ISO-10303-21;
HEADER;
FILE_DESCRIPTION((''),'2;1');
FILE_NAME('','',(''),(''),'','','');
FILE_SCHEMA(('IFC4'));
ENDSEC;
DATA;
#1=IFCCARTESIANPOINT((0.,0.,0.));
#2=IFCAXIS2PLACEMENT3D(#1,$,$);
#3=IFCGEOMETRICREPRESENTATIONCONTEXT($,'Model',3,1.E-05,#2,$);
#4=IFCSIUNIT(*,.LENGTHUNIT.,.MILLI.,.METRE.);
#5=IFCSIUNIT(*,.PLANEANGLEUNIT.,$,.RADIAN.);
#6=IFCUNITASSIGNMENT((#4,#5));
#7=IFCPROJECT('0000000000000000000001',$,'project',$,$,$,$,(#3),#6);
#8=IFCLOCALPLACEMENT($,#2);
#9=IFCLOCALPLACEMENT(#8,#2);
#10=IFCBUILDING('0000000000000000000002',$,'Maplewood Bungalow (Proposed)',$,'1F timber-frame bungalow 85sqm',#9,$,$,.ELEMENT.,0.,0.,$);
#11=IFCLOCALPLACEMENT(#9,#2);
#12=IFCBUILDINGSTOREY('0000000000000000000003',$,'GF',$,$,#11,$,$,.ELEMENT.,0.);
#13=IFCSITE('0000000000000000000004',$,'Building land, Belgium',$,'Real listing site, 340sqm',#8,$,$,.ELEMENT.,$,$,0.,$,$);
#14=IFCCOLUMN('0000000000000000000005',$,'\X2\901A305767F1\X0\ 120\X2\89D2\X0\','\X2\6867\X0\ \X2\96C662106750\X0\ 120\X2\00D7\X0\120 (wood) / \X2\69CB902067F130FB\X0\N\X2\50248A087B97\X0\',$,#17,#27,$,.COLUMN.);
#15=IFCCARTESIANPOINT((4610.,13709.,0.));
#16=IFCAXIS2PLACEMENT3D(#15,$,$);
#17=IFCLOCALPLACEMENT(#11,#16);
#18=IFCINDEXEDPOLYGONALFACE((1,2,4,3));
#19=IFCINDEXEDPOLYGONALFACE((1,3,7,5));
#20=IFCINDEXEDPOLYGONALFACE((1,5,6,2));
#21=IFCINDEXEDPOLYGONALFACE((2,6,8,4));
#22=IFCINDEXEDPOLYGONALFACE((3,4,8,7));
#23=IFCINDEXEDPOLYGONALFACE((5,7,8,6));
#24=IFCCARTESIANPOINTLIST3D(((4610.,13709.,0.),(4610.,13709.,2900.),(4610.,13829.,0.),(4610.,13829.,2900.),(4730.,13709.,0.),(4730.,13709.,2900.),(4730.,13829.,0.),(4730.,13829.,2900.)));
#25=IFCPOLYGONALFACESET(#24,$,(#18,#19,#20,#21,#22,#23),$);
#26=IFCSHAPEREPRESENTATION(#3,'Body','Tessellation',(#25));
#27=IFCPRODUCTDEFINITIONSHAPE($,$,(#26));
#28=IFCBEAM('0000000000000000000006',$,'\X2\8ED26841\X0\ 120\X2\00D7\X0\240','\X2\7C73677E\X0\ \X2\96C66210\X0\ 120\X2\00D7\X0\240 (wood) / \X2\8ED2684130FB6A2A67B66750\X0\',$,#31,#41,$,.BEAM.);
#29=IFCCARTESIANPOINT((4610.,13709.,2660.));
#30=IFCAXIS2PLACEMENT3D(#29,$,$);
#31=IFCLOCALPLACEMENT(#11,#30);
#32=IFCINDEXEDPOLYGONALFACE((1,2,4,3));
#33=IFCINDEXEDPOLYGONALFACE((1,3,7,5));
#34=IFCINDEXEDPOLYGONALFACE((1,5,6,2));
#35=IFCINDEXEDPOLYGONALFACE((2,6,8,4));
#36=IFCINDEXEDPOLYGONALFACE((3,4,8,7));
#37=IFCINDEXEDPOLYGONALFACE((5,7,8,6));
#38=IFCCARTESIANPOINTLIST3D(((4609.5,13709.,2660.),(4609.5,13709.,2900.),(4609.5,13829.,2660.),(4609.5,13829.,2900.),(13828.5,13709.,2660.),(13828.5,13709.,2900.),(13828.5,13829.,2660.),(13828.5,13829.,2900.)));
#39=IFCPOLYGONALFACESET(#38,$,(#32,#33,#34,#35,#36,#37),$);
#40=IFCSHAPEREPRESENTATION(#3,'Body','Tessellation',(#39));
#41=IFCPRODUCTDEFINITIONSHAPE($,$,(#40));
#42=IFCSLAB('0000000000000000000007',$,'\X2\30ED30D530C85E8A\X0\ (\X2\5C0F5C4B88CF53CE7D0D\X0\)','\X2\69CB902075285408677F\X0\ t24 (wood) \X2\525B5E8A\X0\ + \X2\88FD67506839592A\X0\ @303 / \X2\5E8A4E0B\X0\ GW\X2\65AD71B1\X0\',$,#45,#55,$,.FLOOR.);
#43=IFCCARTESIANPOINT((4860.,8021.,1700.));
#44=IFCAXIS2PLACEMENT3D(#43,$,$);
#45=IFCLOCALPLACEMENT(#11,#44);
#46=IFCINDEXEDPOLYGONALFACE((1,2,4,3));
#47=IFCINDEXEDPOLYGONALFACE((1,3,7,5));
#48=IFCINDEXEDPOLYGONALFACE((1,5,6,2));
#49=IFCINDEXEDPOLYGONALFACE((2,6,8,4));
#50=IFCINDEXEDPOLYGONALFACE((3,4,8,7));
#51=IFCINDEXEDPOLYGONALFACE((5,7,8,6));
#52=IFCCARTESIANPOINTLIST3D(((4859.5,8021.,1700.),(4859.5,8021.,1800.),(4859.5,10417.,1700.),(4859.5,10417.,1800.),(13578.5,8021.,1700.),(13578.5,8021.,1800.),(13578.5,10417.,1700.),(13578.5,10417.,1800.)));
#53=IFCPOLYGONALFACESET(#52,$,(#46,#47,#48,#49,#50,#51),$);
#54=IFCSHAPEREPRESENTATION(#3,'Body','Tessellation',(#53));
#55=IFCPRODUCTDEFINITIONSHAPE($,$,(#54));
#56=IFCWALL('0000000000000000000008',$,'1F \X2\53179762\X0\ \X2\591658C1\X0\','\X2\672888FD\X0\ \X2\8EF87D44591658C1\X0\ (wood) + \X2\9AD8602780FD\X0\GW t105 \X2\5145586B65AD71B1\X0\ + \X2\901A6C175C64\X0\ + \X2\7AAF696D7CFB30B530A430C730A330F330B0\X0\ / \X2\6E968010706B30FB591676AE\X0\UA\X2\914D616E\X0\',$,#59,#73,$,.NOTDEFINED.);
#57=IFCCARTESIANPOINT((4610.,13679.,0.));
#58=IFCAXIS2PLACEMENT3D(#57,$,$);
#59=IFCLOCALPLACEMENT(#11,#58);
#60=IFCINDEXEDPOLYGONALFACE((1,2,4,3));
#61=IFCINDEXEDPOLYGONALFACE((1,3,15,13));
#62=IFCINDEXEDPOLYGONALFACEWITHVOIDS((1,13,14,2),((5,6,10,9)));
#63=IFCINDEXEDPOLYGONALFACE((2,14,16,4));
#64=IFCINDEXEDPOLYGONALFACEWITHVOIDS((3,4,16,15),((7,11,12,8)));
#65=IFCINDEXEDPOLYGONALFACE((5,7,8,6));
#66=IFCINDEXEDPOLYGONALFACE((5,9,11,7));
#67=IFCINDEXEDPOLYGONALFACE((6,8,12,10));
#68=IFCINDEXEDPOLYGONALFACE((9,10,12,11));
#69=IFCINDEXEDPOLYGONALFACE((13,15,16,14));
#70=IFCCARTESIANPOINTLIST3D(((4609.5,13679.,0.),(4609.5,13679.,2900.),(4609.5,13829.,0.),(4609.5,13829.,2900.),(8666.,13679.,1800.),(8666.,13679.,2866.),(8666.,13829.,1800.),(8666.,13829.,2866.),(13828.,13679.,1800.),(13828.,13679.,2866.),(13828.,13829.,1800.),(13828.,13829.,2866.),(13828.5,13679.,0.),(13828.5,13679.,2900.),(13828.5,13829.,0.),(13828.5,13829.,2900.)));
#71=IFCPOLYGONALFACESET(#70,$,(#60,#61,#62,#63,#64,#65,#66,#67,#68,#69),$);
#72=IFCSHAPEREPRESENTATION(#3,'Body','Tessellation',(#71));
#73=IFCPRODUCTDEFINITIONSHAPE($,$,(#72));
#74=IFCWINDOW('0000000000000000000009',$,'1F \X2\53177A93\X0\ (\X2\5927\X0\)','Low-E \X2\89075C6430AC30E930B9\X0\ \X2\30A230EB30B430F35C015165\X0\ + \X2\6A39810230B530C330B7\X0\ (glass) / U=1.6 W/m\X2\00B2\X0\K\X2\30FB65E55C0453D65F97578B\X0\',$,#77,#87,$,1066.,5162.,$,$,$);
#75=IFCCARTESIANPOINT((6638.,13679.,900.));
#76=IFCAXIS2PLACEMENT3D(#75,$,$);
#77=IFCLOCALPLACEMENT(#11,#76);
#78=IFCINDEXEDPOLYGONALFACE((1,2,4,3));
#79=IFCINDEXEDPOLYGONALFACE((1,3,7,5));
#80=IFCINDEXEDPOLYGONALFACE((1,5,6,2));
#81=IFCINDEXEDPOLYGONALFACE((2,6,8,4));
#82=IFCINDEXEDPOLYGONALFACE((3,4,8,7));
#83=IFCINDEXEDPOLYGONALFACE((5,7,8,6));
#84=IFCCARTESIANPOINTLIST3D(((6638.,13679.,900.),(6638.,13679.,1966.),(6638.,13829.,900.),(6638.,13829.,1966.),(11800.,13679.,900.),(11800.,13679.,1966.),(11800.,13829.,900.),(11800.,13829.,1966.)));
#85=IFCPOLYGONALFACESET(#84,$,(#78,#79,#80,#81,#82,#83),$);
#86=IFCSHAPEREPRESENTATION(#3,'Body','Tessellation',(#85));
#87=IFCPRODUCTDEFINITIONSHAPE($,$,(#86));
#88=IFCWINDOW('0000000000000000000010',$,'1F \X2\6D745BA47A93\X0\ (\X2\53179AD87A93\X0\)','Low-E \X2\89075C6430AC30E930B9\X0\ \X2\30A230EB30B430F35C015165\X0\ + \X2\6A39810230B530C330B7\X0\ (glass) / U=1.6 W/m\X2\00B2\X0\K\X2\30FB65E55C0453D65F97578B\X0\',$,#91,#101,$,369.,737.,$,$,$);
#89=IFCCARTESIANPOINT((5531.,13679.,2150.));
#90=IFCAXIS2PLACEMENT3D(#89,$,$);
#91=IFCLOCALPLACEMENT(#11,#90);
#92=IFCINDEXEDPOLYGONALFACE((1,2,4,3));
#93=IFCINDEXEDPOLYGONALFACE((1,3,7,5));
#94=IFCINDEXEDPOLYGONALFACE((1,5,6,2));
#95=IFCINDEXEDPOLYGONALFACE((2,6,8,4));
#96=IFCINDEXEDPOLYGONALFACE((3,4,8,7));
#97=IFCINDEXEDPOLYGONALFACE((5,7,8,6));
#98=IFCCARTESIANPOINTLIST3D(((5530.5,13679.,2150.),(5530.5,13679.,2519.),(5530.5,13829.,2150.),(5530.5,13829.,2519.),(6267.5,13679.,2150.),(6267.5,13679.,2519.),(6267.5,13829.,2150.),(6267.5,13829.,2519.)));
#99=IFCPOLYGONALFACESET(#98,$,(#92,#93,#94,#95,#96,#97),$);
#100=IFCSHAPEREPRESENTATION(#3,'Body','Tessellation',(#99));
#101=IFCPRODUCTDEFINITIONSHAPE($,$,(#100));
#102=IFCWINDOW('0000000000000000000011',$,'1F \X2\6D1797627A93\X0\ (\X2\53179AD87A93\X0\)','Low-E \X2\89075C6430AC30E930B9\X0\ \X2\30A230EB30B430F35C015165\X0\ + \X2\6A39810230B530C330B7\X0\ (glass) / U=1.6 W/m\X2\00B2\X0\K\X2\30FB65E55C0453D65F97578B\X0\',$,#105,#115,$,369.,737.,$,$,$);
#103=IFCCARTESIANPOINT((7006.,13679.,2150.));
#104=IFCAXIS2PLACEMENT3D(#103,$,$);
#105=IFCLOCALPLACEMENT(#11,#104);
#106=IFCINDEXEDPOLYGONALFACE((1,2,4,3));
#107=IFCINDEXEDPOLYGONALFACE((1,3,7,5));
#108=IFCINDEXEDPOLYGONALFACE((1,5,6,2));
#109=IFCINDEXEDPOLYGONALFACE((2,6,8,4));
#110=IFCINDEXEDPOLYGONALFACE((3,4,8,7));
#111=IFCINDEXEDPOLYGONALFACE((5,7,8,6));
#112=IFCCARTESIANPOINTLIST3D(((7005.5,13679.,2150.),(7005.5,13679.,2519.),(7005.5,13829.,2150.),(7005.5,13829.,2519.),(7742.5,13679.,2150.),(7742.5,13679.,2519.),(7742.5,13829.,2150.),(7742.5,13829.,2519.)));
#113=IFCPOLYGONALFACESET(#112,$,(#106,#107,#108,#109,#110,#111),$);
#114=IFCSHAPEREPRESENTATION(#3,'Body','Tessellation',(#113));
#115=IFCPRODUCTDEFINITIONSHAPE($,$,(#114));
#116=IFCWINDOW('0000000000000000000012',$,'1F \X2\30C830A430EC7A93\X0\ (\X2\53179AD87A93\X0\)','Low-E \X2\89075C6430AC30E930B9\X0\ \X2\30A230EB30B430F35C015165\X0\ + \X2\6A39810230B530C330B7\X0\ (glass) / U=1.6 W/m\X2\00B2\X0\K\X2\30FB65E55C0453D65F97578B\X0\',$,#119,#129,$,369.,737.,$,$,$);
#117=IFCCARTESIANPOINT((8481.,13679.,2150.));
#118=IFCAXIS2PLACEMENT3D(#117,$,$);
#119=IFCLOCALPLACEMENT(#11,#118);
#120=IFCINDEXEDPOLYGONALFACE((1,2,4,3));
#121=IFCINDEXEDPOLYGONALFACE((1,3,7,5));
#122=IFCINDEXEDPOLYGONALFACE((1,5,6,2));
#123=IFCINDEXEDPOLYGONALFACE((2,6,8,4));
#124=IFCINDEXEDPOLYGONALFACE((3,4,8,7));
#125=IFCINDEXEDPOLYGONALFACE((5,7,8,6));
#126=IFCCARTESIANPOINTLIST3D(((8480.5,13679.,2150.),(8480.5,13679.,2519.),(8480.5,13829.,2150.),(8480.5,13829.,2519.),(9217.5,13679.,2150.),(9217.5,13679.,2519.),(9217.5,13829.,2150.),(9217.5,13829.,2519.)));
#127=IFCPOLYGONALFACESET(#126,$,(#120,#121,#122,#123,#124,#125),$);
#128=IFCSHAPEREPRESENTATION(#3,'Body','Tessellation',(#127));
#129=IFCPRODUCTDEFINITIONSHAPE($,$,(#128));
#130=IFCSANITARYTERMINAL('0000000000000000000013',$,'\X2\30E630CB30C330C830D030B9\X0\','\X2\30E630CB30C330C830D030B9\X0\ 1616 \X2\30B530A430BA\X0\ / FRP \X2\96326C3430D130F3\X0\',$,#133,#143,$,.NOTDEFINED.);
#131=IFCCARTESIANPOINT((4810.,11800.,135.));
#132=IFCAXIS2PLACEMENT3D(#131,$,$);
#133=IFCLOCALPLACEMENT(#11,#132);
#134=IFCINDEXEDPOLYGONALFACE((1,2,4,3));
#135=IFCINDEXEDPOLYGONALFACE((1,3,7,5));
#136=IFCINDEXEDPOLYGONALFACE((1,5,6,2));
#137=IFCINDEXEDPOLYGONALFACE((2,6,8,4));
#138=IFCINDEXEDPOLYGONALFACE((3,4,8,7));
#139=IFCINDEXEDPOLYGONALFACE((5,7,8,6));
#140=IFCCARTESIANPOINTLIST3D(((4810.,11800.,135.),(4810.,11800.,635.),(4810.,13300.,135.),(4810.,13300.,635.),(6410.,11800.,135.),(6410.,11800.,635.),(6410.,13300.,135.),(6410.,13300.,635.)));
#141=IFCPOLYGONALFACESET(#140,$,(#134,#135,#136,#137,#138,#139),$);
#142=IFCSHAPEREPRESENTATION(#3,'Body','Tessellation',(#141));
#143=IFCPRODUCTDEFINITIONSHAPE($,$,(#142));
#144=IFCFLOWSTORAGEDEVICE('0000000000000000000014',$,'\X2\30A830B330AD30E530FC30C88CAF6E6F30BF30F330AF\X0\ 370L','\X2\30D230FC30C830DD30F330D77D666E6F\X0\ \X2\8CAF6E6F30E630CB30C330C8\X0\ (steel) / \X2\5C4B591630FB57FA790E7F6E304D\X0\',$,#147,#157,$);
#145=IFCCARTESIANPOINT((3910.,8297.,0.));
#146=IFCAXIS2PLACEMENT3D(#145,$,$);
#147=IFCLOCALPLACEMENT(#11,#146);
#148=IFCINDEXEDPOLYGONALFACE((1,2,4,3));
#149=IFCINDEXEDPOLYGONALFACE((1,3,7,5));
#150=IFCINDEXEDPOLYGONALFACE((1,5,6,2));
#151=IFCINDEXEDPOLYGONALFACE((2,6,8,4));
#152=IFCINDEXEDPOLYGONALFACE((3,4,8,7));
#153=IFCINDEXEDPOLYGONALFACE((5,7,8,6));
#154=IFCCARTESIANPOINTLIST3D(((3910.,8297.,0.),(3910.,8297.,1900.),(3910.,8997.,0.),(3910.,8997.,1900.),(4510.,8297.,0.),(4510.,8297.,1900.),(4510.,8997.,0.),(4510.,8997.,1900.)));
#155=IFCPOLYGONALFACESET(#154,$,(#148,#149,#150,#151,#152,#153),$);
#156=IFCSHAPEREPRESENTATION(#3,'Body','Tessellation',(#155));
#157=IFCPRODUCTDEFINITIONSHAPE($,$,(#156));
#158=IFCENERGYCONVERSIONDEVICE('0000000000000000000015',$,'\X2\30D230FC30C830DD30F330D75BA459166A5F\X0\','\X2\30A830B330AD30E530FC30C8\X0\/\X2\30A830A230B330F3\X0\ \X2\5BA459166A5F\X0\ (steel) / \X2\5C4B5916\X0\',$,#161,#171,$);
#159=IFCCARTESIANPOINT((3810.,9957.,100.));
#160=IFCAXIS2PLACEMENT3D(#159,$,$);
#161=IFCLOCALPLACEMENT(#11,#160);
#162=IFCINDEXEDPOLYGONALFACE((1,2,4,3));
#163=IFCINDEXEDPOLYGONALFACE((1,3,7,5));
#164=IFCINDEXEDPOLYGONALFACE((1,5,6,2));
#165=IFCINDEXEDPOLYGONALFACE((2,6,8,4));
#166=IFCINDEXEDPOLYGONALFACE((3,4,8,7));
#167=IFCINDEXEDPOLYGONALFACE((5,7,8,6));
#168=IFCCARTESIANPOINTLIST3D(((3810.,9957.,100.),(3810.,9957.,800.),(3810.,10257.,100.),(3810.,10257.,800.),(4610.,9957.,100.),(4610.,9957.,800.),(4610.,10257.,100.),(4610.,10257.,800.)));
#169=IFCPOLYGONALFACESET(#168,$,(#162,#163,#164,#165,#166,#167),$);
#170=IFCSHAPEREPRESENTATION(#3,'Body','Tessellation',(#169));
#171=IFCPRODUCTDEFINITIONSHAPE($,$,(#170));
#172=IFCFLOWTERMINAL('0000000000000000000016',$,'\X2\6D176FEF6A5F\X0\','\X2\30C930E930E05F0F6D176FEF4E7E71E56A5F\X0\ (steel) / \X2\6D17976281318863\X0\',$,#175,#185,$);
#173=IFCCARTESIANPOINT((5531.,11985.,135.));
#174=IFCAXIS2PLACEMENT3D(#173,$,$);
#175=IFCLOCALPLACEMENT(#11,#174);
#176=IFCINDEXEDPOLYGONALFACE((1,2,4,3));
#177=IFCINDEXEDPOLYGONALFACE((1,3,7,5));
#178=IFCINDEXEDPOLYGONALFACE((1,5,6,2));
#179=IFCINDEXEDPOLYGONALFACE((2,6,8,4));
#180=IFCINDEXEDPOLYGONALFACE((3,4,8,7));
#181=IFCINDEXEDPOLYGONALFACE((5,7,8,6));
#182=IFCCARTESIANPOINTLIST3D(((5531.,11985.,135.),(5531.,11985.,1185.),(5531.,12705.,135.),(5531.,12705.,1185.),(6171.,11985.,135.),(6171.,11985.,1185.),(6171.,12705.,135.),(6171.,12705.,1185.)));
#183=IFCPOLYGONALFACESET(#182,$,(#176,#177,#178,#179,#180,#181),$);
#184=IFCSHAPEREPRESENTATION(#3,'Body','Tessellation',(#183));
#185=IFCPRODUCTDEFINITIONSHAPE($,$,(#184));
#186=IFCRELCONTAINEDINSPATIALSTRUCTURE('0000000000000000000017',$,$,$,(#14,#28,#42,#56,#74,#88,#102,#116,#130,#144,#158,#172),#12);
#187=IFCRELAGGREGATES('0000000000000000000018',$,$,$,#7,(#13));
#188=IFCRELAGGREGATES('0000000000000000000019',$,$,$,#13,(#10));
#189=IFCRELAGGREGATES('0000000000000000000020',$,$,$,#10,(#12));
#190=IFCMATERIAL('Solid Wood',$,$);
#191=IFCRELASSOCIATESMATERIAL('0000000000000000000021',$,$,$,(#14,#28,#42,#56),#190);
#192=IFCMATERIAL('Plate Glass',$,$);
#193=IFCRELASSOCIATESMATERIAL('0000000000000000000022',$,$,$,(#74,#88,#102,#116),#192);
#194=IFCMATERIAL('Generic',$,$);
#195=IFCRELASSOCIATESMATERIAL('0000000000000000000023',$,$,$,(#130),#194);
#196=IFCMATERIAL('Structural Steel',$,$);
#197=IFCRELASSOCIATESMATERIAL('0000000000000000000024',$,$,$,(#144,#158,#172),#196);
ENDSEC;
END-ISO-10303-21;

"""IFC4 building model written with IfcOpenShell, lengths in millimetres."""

from ifc_helpers import new_model, si_unit, frame, frame_2d, origin, place, context, project, spatial, rectangle, extrude, material, element, fill, save


model = new_model("IFC4")

# Units and contexts
model_context = context("Model", 3, precision=1e-05, world=origin())
ifc_project = project(units=[si_unit("LENGTHUNIT", "METRE", prefix="MILLI"), si_unit("PLANEANGLEUNIT", "RADIAN")], contexts=[model_context])

# Site, building, storey
site_placement = place(None, origin())
site = spatial("IfcSite", under=ifc_project, at=site_placement, Name="Building land, Belgium", ObjectType="Real listing site, 340sqm", CompositionType="ELEMENT", RefElevation=0.0)
building_placement = place(site_placement, origin())
building = spatial("IfcBuilding", under=site, at=building_placement, Name="Maplewood Bungalow (Proposed)", ObjectType="1F timber-frame bungalow 85sqm", CompositionType="ELEMENT", ElevationOfRefHeight=0.0, ElevationOfTerrain=0.0)
storey_placement = place(building_placement, origin())
storey = spatial("IfcBuildingStorey", under=building, at=storey_placement, Name="GF", CompositionType="ELEMENT", Elevation=0.0)

# Column
ifc_material_1 = material(Name="Solid Wood")
column_1_placement = place(storey_placement, frame((4610.0, 13709.0, 0.0)))
element("IfcColumn", 1, at=column_1_placement, inside=storey, material=ifc_material_1, Name="通し柱 120角", Description="桧 集成材 120×120 (wood) / 構造柱・N値計算", PredefinedType="COLUMN", context=model_context, shape_type="SweptSolid", body=[
    extrude(rectangle(XDim=120.0, YDim=120.0, at=frame_2d((60.0, 60.0))), frame((4610.0, 13709.0, 0.0)), (0.0, 0.0, 1.0), 2900.0),
])

# Beam
beam_1_placement = place(storey_placement, frame((4610.0, 13709.0, 2660.0)))
element("IfcBeam", 2, at=beam_1_placement, inside=storey, material=ifc_material_1, Name="軒桁 120×240", Description="米松 集成 120×240 (wood) / 軒桁・横架材", PredefinedType="BEAM", context=model_context, shape_type="SweptSolid", body=[
    extrude(rectangle(XDim=9219.0, YDim=120.0, at=frame_2d((4609.0, 60.0))), frame((4610.0, 13709.0, 2660.0)), (0.0, 0.0, 1.0), 240.0),
])

# Slab
slab_placement = place(storey_placement, frame((4860.0, 8021.0, 1700.0)))
element("IfcSlab", 3, at=slab_placement, inside=storey, material=ifc_material_1, Name="ロフト床 (小屋裏収納)", Description="構造用合板 t24 (wood) 剛床 + 製材根太 @303 / 床下 GW断熱", PredefinedType="FLOOR", context=model_context, shape_type="SweptSolid", body=[
    extrude(rectangle(XDim=8719.0, YDim=2396.0, at=frame_2d((4359.0, 1198.0))), frame((4860.0, 8021.0, 1700.0)), (0.0, 0.0, 1.0), 100.0),
])

# Wall, openings, windows
wall_1_placement = place(storey_placement, frame((4610.0, 13679.0, 0.0)))
wall_1 = element("IfcWall", 4, at=wall_1_placement, inside=storey, material=ifc_material_1, Name="1F 北面 外壁", Description="木製 軸組外壁 (wood) + 高性能GW t105 充填断熱 + 通気層 + 窯業系サイディング / 準耐火・外皮UA配慮", PredefinedType="NOTDEFINED", context=model_context, shape_type="SweptSolid", body=[
    extrude(rectangle(XDim=9219.0, YDim=150.0, at=frame_2d((4609.0, 75.0))), frame((4610.0, 13679.0, 0.0)), (0.0, 0.0, 1.0), 2900.0),
])
opening_1_placement = place(storey_placement, frame((6638.0, 13679.0, 900.0)))
opening_1 = element("IfcOpeningElement", 5, at=opening_1_placement, cuts=wall_1, PredefinedType="NOTDEFINED", context=model_context, shape_type="SweptSolid", body=[
    extrude(rectangle(XDim=5162.0, YDim=150.0, at=frame_2d((2581.0, 75.0))), frame((6638.0, 13679.0, 900.0)), (0.0, 0.0, 1.0), 1066.0),
])
opening_2_placement = place(storey_placement, frame((5531.0, 13679.0, 2150.0)))
opening_2 = element("IfcOpeningElement", 6, at=opening_2_placement, cuts=wall_1, PredefinedType="NOTDEFINED", context=model_context, shape_type="SweptSolid", body=[
    extrude(rectangle(XDim=737.0, YDim=150.0, at=frame_2d((368.0, 75.0))), frame((5531.0, 13679.0, 2150.0)), (0.0, 0.0, 1.0), 369.0),
])
opening_3_placement = place(storey_placement, frame((7006.0, 13679.0, 2150.0)))
opening_3 = element("IfcOpeningElement", 7, at=opening_3_placement, cuts=wall_1, PredefinedType="NOTDEFINED", context=model_context, shape_type="SweptSolid", body=[
    extrude(rectangle(XDim=737.0, YDim=150.0, at=frame_2d((368.0, 75.0))), frame((7006.0, 13679.0, 2150.0)), (0.0, 0.0, 1.0), 369.0),
])
opening_4_placement = place(storey_placement, frame((8481.0, 13679.0, 2150.0)))
opening_4 = element("IfcOpeningElement", 8, at=opening_4_placement, cuts=wall_1, PredefinedType="NOTDEFINED", context=model_context, shape_type="SweptSolid", body=[
    extrude(rectangle(XDim=737.0, YDim=150.0, at=frame_2d((368.0, 75.0))), frame((8481.0, 13679.0, 2150.0)), (0.0, 0.0, 1.0), 369.0),
])
ifc_material_2 = material(Name="Plate Glass")
window_1_placement = place(storey_placement, frame((6638.0, 13679.0, 900.0)))
window_1 = element("IfcWindow", 9, at=window_1_placement, inside=storey, material=ifc_material_2, Name="1F 北窓 (大)", Description="Low-E 複層ガラス アルゴン封入 + 樹脂サッシ (glass) / U=1.6 W/m²K・日射取得型", OverallHeight=1066.0, OverallWidth=5162.0, context=model_context, shape_type="SweptSolid", body=[
    extrude(rectangle(XDim=5162.0, YDim=150.0, at=frame_2d((2581.0, 75.0))), frame((6638.0, 13679.0, 900.0)), (0.0, 0.0, 1.0), 1066.0),
])
fill(opening_1, window_1)
window_2_placement = place(storey_placement, frame((5531.0, 13679.0, 2150.0)))
window_2 = element("IfcWindow", 10, at=window_2_placement, inside=storey, material=ifc_material_2, Name="1F 浴室窓 (北高窓)", Description="Low-E 複層ガラス アルゴン封入 + 樹脂サッシ (glass) / U=1.6 W/m²K・日射取得型", OverallHeight=369.0, OverallWidth=737.0, context=model_context, shape_type="SweptSolid", body=[
    extrude(rectangle(XDim=737.0, YDim=150.0, at=frame_2d((368.0, 75.0))), frame((5531.0, 13679.0, 2150.0)), (0.0, 0.0, 1.0), 369.0),
])
fill(opening_2, window_2)
window_3_placement = place(storey_placement, frame((7006.0, 13679.0, 2150.0)))
window_3 = element("IfcWindow", 11, at=window_3_placement, inside=storey, material=ifc_material_2, Name="1F 洗面窓 (北高窓)", Description="Low-E 複層ガラス アルゴン封入 + 樹脂サッシ (glass) / U=1.6 W/m²K・日射取得型", OverallHeight=369.0, OverallWidth=737.0, context=model_context, shape_type="SweptSolid", body=[
    extrude(rectangle(XDim=737.0, YDim=150.0, at=frame_2d((368.0, 75.0))), frame((7006.0, 13679.0, 2150.0)), (0.0, 0.0, 1.0), 369.0),
])
fill(opening_3, window_3)
window_4_placement = place(storey_placement, frame((8481.0, 13679.0, 2150.0)))
window_4 = element("IfcWindow", 12, at=window_4_placement, inside=storey, material=ifc_material_2, Name="1F トイレ窓 (北高窓)", Description="Low-E 複層ガラス アルゴン封入 + 樹脂サッシ (glass) / U=1.6 W/m²K・日射取得型", OverallHeight=369.0, OverallWidth=737.0, context=model_context, shape_type="SweptSolid", body=[
    extrude(rectangle(XDim=737.0, YDim=150.0, at=frame_2d((368.0, 75.0))), frame((8481.0, 13679.0, 2150.0)), (0.0, 0.0, 1.0), 369.0),
])
fill(opening_4, window_4)

# Shared definitions
ifc_material_3 = material(Name="Structural Steel")

# Sanitary terminal
ifc_material_4 = material(Name="Generic")
sanitary_terminal_placement = place(storey_placement, frame((4810.0, 11800.0, 135.0)))
element("IfcSanitaryTerminal", 13, at=sanitary_terminal_placement, inside=storey, material=ifc_material_4, Name="ユニットバス", Description="ユニットバス 1616 サイズ / FRP 防水パン", PredefinedType="NOTDEFINED", context=model_context, shape_type="SweptSolid", body=[
    extrude(rectangle(XDim=1600.0, YDim=1500.0, at=frame_2d((800.0, 750.0))), frame((4810.0, 11800.0, 135.0)), (0.0, 0.0, 1.0), 500.0),
])

# Flow storage device
flow_storage_device_placement = place(storey_placement, frame((3910.0, 8297.0, 0.0)))
element("IfcFlowStorageDevice", 14, at=flow_storage_device_placement, inside=storey, material=ifc_material_3, Name="エコキュート貯湯タンク 370L", Description="ヒートポンプ給湯 貯湯ユニット (steel) / 屋外・基礎置き", context=model_context, shape_type="SweptSolid", body=[
    extrude(rectangle(XDim=600.0, YDim=700.0, at=frame_2d((300.0, 350.0))), frame((3910.0, 8297.0, 0.0)), (0.0, 0.0, 1.0), 1900.0),
])

# Energy conversion device
energy_conversion_device_placement = place(storey_placement, frame((3810.0, 9957.0, 100.0)))
element("IfcEnergyConversionDevice", 15, at=energy_conversion_device_placement, inside=storey, material=ifc_material_3, Name="ヒートポンプ室外機", Description="エコキュート/エアコン 室外機 (steel) / 屋外", context=model_context, shape_type="SweptSolid", body=[
    extrude(rectangle(XDim=800.0, YDim=300.0, at=frame_2d((400.0, 150.0))), frame((3810.0, 9957.0, 100.0)), (0.0, 0.0, 1.0), 700.0),
])

# Flow terminal
flow_terminal_placement = place(storey_placement, frame((5531.0, 11985.0, 135.0)))
element("IfcFlowTerminal", 16, at=flow_terminal_placement, inside=storey, material=ifc_material_3, Name="洗濯機", Description="ドラム式洗濯乾燥機 (steel) / 洗面脱衣", context=model_context, shape_type="SweptSolid", body=[
    extrude(rectangle(XDim=640.0, YDim=720.0, at=frame_2d((320.0, 360.0))), frame((5531.0, 11985.0, 135.0)), (0.0, 0.0, 1.0), 1050.0),
])

save(model, "model.ifc")
